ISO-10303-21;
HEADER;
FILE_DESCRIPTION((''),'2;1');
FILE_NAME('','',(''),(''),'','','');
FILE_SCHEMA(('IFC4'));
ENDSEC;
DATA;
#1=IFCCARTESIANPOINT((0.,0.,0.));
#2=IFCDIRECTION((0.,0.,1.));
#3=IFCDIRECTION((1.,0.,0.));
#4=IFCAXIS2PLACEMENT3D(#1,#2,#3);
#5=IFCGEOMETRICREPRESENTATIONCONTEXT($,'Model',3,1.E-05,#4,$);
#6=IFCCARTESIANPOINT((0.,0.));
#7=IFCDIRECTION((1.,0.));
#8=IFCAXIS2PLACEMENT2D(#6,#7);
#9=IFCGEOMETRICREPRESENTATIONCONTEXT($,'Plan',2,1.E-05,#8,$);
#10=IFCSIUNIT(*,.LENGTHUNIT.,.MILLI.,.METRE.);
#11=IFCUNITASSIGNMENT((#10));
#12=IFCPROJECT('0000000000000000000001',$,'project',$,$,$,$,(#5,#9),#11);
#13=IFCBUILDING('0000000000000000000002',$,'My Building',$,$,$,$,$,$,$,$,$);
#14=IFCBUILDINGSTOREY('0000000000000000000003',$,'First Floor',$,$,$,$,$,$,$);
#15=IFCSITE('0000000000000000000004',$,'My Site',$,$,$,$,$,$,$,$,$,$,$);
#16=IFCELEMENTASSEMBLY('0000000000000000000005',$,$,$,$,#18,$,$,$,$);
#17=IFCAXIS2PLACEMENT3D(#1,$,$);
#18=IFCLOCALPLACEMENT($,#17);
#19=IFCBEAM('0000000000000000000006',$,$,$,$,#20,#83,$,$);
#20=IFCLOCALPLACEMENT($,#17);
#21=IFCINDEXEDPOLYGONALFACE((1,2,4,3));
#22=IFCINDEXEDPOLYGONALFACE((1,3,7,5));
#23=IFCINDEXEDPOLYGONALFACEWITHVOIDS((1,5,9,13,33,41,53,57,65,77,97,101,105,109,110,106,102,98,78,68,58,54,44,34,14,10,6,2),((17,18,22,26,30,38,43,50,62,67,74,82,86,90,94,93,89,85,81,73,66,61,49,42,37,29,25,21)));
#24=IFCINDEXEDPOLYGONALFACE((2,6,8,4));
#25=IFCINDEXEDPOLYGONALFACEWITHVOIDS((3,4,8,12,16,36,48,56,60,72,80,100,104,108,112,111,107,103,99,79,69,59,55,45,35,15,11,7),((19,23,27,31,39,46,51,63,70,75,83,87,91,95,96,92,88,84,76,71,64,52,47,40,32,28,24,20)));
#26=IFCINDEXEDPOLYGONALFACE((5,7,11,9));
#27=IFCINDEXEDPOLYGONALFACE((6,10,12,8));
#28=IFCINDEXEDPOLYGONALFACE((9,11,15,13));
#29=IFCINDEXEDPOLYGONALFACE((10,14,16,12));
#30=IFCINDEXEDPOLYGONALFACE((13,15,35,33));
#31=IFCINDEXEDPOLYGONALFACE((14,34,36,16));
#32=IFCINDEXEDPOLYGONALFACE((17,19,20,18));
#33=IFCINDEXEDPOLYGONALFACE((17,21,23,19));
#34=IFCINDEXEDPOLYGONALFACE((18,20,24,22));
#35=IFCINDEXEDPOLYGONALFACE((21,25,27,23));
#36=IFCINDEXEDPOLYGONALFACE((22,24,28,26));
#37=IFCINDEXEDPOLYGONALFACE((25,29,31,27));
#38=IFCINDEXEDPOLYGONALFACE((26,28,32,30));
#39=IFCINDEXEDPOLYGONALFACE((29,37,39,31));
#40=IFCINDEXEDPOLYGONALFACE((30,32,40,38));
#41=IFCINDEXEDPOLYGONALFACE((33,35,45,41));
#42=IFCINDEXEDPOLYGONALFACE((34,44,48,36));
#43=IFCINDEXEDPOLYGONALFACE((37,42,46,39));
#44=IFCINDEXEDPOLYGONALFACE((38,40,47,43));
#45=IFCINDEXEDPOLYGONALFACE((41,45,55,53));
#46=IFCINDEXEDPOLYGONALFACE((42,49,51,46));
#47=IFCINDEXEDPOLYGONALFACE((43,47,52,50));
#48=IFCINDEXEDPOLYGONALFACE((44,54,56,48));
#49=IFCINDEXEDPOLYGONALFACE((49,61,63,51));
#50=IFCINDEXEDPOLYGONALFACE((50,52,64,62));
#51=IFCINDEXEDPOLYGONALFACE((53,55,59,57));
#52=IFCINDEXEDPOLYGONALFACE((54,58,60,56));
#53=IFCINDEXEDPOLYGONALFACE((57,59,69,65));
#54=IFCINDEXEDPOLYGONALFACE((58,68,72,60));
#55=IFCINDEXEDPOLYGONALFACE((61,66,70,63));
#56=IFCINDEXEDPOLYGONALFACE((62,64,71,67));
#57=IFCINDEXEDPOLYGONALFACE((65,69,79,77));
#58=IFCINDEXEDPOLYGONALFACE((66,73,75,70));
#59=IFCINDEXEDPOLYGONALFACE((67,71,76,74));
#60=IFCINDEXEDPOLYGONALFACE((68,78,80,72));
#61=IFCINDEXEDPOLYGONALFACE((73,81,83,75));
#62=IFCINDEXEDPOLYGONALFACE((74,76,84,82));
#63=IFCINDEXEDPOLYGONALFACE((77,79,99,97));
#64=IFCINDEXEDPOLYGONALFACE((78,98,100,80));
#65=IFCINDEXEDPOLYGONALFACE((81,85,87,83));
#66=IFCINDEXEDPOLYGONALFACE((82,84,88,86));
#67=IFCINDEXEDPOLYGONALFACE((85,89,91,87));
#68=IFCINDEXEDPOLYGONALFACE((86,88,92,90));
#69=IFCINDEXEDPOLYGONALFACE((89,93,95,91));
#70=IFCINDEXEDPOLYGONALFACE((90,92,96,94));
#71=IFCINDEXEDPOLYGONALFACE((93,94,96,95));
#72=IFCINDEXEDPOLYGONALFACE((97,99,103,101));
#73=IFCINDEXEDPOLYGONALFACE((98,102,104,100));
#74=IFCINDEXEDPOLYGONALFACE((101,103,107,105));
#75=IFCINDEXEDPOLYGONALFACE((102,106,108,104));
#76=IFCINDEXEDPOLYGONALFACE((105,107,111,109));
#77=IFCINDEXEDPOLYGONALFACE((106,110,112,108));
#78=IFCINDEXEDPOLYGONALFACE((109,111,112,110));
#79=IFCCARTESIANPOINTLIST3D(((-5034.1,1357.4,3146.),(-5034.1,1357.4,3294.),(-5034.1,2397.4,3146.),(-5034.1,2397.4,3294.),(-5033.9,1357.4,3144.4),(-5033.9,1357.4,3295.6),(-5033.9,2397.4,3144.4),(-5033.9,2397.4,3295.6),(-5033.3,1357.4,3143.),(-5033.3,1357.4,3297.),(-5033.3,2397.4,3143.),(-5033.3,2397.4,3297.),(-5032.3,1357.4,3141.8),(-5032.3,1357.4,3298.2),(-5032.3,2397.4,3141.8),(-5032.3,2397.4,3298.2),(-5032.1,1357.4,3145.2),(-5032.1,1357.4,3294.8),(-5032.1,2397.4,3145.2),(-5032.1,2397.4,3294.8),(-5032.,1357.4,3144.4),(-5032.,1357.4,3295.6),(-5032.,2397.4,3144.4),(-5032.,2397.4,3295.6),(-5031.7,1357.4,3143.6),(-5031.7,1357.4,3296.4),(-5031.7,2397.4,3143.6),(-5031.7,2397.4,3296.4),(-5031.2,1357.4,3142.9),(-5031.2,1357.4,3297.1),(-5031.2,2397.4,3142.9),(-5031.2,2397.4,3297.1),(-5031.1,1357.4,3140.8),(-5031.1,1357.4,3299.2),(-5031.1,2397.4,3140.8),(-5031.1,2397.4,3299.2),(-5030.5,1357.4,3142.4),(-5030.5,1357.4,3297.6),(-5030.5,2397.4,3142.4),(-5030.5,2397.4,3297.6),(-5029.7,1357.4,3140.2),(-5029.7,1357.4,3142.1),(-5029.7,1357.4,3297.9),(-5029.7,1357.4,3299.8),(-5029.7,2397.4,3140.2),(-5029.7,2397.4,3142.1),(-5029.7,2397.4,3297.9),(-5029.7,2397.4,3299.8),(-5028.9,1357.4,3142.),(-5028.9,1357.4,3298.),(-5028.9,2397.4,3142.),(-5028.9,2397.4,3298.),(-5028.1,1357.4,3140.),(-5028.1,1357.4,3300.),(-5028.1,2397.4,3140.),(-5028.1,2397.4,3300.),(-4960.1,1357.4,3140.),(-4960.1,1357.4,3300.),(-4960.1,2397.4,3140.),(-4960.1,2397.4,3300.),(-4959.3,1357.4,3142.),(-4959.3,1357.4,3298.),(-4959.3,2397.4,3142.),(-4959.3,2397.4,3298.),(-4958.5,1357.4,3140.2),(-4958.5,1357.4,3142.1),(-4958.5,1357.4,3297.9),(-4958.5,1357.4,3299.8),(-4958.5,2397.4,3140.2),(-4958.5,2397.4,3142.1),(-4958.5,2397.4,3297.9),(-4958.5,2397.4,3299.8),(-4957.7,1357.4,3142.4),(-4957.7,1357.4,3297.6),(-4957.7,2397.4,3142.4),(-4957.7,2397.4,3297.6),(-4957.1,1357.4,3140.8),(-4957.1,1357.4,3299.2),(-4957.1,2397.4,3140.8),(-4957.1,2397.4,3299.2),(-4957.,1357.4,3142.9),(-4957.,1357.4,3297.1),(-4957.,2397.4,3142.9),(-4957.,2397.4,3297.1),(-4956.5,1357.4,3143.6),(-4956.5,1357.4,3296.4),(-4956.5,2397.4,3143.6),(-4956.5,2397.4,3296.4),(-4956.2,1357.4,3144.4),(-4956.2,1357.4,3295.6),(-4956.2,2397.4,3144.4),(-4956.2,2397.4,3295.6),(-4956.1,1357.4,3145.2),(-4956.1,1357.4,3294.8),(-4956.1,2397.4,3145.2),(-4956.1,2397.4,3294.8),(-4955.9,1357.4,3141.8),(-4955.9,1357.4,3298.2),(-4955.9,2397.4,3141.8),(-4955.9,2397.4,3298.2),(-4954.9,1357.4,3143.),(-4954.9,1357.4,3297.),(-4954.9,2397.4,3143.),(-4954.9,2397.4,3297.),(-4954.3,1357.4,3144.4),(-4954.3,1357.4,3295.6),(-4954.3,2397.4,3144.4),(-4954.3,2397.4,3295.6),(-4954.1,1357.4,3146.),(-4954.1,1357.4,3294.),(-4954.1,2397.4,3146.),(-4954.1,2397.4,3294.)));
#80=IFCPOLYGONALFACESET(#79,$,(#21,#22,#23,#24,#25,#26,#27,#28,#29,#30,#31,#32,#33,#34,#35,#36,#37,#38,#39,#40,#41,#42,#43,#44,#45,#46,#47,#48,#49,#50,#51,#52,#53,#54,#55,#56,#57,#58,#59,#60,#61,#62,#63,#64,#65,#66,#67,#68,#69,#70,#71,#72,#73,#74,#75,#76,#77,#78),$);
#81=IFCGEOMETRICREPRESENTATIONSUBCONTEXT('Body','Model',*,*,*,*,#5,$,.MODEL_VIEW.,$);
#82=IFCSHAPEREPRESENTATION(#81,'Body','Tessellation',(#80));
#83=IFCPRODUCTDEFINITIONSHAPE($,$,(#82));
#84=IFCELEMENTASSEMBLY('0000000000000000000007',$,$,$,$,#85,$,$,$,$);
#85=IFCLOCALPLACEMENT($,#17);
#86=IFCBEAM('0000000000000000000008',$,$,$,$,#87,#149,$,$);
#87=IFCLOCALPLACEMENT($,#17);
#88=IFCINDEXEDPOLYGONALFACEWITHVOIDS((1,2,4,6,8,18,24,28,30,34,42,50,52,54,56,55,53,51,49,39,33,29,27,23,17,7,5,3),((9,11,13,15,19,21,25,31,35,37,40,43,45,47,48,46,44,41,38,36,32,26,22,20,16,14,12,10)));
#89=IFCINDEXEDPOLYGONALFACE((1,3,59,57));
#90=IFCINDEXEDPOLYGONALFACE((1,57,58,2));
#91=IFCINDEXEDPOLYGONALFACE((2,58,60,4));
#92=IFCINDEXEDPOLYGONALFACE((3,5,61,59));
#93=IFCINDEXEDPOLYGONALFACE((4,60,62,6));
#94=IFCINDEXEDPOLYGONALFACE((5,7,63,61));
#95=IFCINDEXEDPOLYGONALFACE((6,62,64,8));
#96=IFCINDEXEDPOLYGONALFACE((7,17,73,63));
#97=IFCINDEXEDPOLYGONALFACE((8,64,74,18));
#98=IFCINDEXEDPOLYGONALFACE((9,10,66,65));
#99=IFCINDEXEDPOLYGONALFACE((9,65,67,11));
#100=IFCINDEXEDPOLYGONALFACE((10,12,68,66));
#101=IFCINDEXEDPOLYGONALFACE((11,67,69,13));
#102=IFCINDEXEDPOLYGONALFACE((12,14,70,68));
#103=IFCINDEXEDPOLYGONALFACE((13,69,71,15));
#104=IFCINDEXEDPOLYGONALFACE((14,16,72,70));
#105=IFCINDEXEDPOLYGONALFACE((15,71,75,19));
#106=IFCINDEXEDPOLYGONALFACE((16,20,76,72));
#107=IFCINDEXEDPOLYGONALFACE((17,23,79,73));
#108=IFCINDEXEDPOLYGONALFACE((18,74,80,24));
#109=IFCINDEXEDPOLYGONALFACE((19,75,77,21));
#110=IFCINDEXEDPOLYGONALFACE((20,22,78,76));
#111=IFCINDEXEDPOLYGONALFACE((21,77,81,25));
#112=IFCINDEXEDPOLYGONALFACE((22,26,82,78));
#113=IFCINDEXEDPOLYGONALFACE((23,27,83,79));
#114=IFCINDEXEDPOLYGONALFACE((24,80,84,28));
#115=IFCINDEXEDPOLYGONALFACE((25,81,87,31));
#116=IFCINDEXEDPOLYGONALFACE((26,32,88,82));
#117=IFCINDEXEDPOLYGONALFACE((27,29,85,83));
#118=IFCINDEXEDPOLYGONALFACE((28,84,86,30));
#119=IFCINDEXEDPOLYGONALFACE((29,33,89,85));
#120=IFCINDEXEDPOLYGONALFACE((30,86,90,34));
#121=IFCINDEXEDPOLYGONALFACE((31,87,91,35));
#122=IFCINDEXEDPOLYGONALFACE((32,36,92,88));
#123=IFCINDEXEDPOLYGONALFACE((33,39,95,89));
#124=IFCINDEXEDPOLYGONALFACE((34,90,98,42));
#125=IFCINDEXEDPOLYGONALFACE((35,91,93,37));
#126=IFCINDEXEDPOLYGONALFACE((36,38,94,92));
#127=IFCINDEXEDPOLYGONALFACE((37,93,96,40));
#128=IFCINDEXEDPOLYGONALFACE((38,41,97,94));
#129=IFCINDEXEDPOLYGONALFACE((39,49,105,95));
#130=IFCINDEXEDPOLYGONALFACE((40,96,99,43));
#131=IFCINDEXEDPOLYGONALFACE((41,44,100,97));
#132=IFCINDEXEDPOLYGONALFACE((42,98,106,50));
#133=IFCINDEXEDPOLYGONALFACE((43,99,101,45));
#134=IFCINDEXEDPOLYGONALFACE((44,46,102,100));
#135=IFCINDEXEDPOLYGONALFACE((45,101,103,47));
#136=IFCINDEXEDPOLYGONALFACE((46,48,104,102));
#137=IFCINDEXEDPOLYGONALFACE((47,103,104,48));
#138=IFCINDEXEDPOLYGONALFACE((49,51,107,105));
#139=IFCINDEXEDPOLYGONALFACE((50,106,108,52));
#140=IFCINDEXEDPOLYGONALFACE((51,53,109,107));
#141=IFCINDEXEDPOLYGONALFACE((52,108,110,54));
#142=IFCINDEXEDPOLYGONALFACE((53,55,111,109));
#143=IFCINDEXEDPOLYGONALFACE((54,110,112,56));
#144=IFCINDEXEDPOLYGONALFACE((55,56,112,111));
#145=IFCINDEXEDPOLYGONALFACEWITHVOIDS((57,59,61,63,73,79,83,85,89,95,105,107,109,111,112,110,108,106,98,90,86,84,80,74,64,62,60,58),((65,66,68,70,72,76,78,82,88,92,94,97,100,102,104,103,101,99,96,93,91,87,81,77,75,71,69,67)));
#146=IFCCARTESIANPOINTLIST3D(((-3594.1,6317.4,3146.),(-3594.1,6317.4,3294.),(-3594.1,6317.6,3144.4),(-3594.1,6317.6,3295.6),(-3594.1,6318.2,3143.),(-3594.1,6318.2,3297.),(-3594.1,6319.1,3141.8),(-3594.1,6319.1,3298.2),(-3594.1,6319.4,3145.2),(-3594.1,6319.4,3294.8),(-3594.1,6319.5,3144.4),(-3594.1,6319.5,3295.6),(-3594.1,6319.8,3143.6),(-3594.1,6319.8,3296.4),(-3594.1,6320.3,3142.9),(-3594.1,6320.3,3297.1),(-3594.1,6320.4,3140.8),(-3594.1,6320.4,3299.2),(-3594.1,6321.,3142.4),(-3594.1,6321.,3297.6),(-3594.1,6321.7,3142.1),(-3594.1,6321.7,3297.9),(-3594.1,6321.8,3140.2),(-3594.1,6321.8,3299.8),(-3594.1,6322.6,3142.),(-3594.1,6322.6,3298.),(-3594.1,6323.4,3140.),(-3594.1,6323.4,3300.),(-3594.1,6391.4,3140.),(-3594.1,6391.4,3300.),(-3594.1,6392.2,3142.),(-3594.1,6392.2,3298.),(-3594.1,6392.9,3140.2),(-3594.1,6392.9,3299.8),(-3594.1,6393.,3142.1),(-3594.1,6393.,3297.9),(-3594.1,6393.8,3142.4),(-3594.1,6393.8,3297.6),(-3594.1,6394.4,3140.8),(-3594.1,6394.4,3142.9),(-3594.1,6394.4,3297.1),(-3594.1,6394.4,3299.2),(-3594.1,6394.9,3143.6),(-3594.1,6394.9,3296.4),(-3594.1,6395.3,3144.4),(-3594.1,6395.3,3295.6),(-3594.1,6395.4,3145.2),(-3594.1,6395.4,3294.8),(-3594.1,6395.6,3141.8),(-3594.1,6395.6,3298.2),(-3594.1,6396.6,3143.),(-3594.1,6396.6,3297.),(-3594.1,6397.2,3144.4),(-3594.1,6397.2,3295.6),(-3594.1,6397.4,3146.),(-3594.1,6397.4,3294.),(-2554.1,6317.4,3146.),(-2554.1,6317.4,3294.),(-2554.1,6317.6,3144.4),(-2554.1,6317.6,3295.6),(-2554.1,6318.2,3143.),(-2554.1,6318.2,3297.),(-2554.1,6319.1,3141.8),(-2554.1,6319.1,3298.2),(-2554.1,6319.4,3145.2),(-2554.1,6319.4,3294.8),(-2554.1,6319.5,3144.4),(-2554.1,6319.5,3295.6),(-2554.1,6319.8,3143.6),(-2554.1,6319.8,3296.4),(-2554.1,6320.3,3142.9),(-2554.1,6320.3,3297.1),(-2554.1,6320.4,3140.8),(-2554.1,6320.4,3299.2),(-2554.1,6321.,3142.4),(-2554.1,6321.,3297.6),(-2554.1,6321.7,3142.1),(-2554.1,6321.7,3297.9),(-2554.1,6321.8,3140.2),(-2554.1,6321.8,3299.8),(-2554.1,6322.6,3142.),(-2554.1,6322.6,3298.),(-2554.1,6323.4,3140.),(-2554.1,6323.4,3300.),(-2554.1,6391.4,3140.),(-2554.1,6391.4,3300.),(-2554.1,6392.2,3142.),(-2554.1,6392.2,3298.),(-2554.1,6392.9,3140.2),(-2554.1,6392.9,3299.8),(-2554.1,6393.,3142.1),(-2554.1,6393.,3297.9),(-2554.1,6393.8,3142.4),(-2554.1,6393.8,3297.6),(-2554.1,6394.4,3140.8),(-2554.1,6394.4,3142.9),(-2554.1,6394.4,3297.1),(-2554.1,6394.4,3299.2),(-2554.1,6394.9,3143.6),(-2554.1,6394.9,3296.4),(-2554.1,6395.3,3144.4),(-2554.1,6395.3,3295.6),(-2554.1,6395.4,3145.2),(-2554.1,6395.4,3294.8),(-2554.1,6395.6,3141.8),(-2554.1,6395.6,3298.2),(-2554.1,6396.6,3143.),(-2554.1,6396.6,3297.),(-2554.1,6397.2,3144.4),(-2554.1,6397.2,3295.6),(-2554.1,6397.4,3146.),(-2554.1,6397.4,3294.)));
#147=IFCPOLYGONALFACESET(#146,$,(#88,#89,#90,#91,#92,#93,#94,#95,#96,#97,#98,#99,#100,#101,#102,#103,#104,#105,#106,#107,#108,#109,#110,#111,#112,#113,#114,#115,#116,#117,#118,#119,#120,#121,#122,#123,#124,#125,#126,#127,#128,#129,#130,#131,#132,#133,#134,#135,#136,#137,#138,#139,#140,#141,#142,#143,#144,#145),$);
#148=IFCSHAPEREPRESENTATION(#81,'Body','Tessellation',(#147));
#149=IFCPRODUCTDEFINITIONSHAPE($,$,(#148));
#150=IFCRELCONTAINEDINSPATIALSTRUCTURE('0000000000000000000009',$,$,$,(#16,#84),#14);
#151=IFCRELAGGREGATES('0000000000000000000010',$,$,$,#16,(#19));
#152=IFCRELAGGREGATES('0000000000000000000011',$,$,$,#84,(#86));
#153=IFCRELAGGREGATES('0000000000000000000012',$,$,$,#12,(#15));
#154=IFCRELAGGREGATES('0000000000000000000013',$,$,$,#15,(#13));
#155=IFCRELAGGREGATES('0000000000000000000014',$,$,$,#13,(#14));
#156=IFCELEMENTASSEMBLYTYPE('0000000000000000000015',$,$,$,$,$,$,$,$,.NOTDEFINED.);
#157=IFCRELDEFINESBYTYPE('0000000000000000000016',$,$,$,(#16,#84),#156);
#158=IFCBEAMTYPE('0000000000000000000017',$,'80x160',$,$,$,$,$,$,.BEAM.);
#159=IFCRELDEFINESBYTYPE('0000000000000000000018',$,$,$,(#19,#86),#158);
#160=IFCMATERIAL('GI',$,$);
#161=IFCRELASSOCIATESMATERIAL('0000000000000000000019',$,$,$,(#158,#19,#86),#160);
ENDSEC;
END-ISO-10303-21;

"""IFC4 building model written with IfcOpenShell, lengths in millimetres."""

from ifc_helpers import new_model, si_unit, frame, origin_with_axes, origin_2d_with_axis, place, context, subcontext, project, spatial, hollow_rectangle, extrude, material, material_profile, profile_set, profile_usage, type_object, element, aggregate, save


model = new_model("IFC4")

# Units and contexts
model_context = context("Model", 3, precision=1e-05, world=origin_with_axes())
plan_context = context("Plan", 2, precision=1e-05, world=origin_2d_with_axis())
body_context = subcontext(model_context, "Body", "Model", "MODEL_VIEW")
ifc_project = project(units=[si_unit("LENGTHUNIT", "METRE", prefix="MILLI")], contexts=[model_context, plan_context])

# Site, building, storey
site = spatial("IfcSite", under=ifc_project, Name="My Site")
building = spatial("IfcBuilding", under=site, Name="My Building")
storey = spatial("IfcBuildingStorey", under=building, Name="First Floor")

# Element assemblies, beams
element_assembly_type = type_object("IfcElementAssemblyType", PredefinedType="NOTDEFINED")
ifc_material = material(Name="GI")
ifc_material_profile = material_profile(ifc_material, hollow_rectangle(XDim=80.0, YDim=160.0, WallThickness=2.0, InnerFilletRadius=3.2, OuterFilletRadius=6.0))
ifc_profile_set = profile_set([ifc_material_profile], Name="80x160 GI Rectangular Hollow")
beam_type = type_object("IfcBeamType", Name="80x160", PredefinedType="BEAM", material=ifc_profile_set)
assembly_1_placement = place(None, frame((-4994.1, 1277.4, 3220.0), z_axis=(0.0, 1.0, 0.0), x_axis=(1.0, 0.0, 0.0)))
assembly_1 = element("IfcElementAssembly", 1, at=assembly_1_placement, inside=storey, type_object=element_assembly_type)
ifc_profile_usage_1 = profile_usage(ifc_profile_set)
beam_1_placement = place(assembly_1_placement, frame((0.0, 0.0, 80.0), z_axis=(0.0, 0.0, 1.0), x_axis=(1.0, 0.0, 0.0)))
beam_1 = element("IfcBeam", 2, at=beam_1_placement, type_object=beam_type, material=ifc_profile_usage_1, context=body_context, shape_type="SweptSolid", body=[
    extrude(hollow_rectangle(XDim=80.0, YDim=160.0, WallThickness=2.0, InnerFilletRadius=3.2, OuterFilletRadius=6.0), origin_with_axes(), (0.0, 0.0, 1.0), 1040.0),
])
aggregate(assembly_1, [beam_1])
assembly_2_placement = place(None, frame((-3674.1, 6357.4, 3220.0), z_axis=(1.0, 0.0, 0.0), x_axis=(0.0, 1.0, 0.0)))
assembly_2 = element("IfcElementAssembly", 3, at=assembly_2_placement, inside=storey, type_object=element_assembly_type)
ifc_profile_usage_2 = profile_usage(ifc_profile_set)
beam_2_placement = place(assembly_2_placement, frame((0.0, 0.0, 80.0), z_axis=(0.0, 0.0, 1.0), x_axis=(1.0, 0.0, 0.0)))
beam_2 = element("IfcBeam", 4, at=beam_2_placement, type_object=beam_type, material=ifc_profile_usage_2, context=body_context, shape_type="SweptSolid", body=[
    extrude(hollow_rectangle(XDim=80.0, YDim=160.0, WallThickness=2.0, InnerFilletRadius=3.2, OuterFilletRadius=6.0), origin_with_axes(), (0.0, 0.0, 1.0), 1040.0),
])
aggregate(assembly_2, [beam_2])

save(model, "model.ifc")
